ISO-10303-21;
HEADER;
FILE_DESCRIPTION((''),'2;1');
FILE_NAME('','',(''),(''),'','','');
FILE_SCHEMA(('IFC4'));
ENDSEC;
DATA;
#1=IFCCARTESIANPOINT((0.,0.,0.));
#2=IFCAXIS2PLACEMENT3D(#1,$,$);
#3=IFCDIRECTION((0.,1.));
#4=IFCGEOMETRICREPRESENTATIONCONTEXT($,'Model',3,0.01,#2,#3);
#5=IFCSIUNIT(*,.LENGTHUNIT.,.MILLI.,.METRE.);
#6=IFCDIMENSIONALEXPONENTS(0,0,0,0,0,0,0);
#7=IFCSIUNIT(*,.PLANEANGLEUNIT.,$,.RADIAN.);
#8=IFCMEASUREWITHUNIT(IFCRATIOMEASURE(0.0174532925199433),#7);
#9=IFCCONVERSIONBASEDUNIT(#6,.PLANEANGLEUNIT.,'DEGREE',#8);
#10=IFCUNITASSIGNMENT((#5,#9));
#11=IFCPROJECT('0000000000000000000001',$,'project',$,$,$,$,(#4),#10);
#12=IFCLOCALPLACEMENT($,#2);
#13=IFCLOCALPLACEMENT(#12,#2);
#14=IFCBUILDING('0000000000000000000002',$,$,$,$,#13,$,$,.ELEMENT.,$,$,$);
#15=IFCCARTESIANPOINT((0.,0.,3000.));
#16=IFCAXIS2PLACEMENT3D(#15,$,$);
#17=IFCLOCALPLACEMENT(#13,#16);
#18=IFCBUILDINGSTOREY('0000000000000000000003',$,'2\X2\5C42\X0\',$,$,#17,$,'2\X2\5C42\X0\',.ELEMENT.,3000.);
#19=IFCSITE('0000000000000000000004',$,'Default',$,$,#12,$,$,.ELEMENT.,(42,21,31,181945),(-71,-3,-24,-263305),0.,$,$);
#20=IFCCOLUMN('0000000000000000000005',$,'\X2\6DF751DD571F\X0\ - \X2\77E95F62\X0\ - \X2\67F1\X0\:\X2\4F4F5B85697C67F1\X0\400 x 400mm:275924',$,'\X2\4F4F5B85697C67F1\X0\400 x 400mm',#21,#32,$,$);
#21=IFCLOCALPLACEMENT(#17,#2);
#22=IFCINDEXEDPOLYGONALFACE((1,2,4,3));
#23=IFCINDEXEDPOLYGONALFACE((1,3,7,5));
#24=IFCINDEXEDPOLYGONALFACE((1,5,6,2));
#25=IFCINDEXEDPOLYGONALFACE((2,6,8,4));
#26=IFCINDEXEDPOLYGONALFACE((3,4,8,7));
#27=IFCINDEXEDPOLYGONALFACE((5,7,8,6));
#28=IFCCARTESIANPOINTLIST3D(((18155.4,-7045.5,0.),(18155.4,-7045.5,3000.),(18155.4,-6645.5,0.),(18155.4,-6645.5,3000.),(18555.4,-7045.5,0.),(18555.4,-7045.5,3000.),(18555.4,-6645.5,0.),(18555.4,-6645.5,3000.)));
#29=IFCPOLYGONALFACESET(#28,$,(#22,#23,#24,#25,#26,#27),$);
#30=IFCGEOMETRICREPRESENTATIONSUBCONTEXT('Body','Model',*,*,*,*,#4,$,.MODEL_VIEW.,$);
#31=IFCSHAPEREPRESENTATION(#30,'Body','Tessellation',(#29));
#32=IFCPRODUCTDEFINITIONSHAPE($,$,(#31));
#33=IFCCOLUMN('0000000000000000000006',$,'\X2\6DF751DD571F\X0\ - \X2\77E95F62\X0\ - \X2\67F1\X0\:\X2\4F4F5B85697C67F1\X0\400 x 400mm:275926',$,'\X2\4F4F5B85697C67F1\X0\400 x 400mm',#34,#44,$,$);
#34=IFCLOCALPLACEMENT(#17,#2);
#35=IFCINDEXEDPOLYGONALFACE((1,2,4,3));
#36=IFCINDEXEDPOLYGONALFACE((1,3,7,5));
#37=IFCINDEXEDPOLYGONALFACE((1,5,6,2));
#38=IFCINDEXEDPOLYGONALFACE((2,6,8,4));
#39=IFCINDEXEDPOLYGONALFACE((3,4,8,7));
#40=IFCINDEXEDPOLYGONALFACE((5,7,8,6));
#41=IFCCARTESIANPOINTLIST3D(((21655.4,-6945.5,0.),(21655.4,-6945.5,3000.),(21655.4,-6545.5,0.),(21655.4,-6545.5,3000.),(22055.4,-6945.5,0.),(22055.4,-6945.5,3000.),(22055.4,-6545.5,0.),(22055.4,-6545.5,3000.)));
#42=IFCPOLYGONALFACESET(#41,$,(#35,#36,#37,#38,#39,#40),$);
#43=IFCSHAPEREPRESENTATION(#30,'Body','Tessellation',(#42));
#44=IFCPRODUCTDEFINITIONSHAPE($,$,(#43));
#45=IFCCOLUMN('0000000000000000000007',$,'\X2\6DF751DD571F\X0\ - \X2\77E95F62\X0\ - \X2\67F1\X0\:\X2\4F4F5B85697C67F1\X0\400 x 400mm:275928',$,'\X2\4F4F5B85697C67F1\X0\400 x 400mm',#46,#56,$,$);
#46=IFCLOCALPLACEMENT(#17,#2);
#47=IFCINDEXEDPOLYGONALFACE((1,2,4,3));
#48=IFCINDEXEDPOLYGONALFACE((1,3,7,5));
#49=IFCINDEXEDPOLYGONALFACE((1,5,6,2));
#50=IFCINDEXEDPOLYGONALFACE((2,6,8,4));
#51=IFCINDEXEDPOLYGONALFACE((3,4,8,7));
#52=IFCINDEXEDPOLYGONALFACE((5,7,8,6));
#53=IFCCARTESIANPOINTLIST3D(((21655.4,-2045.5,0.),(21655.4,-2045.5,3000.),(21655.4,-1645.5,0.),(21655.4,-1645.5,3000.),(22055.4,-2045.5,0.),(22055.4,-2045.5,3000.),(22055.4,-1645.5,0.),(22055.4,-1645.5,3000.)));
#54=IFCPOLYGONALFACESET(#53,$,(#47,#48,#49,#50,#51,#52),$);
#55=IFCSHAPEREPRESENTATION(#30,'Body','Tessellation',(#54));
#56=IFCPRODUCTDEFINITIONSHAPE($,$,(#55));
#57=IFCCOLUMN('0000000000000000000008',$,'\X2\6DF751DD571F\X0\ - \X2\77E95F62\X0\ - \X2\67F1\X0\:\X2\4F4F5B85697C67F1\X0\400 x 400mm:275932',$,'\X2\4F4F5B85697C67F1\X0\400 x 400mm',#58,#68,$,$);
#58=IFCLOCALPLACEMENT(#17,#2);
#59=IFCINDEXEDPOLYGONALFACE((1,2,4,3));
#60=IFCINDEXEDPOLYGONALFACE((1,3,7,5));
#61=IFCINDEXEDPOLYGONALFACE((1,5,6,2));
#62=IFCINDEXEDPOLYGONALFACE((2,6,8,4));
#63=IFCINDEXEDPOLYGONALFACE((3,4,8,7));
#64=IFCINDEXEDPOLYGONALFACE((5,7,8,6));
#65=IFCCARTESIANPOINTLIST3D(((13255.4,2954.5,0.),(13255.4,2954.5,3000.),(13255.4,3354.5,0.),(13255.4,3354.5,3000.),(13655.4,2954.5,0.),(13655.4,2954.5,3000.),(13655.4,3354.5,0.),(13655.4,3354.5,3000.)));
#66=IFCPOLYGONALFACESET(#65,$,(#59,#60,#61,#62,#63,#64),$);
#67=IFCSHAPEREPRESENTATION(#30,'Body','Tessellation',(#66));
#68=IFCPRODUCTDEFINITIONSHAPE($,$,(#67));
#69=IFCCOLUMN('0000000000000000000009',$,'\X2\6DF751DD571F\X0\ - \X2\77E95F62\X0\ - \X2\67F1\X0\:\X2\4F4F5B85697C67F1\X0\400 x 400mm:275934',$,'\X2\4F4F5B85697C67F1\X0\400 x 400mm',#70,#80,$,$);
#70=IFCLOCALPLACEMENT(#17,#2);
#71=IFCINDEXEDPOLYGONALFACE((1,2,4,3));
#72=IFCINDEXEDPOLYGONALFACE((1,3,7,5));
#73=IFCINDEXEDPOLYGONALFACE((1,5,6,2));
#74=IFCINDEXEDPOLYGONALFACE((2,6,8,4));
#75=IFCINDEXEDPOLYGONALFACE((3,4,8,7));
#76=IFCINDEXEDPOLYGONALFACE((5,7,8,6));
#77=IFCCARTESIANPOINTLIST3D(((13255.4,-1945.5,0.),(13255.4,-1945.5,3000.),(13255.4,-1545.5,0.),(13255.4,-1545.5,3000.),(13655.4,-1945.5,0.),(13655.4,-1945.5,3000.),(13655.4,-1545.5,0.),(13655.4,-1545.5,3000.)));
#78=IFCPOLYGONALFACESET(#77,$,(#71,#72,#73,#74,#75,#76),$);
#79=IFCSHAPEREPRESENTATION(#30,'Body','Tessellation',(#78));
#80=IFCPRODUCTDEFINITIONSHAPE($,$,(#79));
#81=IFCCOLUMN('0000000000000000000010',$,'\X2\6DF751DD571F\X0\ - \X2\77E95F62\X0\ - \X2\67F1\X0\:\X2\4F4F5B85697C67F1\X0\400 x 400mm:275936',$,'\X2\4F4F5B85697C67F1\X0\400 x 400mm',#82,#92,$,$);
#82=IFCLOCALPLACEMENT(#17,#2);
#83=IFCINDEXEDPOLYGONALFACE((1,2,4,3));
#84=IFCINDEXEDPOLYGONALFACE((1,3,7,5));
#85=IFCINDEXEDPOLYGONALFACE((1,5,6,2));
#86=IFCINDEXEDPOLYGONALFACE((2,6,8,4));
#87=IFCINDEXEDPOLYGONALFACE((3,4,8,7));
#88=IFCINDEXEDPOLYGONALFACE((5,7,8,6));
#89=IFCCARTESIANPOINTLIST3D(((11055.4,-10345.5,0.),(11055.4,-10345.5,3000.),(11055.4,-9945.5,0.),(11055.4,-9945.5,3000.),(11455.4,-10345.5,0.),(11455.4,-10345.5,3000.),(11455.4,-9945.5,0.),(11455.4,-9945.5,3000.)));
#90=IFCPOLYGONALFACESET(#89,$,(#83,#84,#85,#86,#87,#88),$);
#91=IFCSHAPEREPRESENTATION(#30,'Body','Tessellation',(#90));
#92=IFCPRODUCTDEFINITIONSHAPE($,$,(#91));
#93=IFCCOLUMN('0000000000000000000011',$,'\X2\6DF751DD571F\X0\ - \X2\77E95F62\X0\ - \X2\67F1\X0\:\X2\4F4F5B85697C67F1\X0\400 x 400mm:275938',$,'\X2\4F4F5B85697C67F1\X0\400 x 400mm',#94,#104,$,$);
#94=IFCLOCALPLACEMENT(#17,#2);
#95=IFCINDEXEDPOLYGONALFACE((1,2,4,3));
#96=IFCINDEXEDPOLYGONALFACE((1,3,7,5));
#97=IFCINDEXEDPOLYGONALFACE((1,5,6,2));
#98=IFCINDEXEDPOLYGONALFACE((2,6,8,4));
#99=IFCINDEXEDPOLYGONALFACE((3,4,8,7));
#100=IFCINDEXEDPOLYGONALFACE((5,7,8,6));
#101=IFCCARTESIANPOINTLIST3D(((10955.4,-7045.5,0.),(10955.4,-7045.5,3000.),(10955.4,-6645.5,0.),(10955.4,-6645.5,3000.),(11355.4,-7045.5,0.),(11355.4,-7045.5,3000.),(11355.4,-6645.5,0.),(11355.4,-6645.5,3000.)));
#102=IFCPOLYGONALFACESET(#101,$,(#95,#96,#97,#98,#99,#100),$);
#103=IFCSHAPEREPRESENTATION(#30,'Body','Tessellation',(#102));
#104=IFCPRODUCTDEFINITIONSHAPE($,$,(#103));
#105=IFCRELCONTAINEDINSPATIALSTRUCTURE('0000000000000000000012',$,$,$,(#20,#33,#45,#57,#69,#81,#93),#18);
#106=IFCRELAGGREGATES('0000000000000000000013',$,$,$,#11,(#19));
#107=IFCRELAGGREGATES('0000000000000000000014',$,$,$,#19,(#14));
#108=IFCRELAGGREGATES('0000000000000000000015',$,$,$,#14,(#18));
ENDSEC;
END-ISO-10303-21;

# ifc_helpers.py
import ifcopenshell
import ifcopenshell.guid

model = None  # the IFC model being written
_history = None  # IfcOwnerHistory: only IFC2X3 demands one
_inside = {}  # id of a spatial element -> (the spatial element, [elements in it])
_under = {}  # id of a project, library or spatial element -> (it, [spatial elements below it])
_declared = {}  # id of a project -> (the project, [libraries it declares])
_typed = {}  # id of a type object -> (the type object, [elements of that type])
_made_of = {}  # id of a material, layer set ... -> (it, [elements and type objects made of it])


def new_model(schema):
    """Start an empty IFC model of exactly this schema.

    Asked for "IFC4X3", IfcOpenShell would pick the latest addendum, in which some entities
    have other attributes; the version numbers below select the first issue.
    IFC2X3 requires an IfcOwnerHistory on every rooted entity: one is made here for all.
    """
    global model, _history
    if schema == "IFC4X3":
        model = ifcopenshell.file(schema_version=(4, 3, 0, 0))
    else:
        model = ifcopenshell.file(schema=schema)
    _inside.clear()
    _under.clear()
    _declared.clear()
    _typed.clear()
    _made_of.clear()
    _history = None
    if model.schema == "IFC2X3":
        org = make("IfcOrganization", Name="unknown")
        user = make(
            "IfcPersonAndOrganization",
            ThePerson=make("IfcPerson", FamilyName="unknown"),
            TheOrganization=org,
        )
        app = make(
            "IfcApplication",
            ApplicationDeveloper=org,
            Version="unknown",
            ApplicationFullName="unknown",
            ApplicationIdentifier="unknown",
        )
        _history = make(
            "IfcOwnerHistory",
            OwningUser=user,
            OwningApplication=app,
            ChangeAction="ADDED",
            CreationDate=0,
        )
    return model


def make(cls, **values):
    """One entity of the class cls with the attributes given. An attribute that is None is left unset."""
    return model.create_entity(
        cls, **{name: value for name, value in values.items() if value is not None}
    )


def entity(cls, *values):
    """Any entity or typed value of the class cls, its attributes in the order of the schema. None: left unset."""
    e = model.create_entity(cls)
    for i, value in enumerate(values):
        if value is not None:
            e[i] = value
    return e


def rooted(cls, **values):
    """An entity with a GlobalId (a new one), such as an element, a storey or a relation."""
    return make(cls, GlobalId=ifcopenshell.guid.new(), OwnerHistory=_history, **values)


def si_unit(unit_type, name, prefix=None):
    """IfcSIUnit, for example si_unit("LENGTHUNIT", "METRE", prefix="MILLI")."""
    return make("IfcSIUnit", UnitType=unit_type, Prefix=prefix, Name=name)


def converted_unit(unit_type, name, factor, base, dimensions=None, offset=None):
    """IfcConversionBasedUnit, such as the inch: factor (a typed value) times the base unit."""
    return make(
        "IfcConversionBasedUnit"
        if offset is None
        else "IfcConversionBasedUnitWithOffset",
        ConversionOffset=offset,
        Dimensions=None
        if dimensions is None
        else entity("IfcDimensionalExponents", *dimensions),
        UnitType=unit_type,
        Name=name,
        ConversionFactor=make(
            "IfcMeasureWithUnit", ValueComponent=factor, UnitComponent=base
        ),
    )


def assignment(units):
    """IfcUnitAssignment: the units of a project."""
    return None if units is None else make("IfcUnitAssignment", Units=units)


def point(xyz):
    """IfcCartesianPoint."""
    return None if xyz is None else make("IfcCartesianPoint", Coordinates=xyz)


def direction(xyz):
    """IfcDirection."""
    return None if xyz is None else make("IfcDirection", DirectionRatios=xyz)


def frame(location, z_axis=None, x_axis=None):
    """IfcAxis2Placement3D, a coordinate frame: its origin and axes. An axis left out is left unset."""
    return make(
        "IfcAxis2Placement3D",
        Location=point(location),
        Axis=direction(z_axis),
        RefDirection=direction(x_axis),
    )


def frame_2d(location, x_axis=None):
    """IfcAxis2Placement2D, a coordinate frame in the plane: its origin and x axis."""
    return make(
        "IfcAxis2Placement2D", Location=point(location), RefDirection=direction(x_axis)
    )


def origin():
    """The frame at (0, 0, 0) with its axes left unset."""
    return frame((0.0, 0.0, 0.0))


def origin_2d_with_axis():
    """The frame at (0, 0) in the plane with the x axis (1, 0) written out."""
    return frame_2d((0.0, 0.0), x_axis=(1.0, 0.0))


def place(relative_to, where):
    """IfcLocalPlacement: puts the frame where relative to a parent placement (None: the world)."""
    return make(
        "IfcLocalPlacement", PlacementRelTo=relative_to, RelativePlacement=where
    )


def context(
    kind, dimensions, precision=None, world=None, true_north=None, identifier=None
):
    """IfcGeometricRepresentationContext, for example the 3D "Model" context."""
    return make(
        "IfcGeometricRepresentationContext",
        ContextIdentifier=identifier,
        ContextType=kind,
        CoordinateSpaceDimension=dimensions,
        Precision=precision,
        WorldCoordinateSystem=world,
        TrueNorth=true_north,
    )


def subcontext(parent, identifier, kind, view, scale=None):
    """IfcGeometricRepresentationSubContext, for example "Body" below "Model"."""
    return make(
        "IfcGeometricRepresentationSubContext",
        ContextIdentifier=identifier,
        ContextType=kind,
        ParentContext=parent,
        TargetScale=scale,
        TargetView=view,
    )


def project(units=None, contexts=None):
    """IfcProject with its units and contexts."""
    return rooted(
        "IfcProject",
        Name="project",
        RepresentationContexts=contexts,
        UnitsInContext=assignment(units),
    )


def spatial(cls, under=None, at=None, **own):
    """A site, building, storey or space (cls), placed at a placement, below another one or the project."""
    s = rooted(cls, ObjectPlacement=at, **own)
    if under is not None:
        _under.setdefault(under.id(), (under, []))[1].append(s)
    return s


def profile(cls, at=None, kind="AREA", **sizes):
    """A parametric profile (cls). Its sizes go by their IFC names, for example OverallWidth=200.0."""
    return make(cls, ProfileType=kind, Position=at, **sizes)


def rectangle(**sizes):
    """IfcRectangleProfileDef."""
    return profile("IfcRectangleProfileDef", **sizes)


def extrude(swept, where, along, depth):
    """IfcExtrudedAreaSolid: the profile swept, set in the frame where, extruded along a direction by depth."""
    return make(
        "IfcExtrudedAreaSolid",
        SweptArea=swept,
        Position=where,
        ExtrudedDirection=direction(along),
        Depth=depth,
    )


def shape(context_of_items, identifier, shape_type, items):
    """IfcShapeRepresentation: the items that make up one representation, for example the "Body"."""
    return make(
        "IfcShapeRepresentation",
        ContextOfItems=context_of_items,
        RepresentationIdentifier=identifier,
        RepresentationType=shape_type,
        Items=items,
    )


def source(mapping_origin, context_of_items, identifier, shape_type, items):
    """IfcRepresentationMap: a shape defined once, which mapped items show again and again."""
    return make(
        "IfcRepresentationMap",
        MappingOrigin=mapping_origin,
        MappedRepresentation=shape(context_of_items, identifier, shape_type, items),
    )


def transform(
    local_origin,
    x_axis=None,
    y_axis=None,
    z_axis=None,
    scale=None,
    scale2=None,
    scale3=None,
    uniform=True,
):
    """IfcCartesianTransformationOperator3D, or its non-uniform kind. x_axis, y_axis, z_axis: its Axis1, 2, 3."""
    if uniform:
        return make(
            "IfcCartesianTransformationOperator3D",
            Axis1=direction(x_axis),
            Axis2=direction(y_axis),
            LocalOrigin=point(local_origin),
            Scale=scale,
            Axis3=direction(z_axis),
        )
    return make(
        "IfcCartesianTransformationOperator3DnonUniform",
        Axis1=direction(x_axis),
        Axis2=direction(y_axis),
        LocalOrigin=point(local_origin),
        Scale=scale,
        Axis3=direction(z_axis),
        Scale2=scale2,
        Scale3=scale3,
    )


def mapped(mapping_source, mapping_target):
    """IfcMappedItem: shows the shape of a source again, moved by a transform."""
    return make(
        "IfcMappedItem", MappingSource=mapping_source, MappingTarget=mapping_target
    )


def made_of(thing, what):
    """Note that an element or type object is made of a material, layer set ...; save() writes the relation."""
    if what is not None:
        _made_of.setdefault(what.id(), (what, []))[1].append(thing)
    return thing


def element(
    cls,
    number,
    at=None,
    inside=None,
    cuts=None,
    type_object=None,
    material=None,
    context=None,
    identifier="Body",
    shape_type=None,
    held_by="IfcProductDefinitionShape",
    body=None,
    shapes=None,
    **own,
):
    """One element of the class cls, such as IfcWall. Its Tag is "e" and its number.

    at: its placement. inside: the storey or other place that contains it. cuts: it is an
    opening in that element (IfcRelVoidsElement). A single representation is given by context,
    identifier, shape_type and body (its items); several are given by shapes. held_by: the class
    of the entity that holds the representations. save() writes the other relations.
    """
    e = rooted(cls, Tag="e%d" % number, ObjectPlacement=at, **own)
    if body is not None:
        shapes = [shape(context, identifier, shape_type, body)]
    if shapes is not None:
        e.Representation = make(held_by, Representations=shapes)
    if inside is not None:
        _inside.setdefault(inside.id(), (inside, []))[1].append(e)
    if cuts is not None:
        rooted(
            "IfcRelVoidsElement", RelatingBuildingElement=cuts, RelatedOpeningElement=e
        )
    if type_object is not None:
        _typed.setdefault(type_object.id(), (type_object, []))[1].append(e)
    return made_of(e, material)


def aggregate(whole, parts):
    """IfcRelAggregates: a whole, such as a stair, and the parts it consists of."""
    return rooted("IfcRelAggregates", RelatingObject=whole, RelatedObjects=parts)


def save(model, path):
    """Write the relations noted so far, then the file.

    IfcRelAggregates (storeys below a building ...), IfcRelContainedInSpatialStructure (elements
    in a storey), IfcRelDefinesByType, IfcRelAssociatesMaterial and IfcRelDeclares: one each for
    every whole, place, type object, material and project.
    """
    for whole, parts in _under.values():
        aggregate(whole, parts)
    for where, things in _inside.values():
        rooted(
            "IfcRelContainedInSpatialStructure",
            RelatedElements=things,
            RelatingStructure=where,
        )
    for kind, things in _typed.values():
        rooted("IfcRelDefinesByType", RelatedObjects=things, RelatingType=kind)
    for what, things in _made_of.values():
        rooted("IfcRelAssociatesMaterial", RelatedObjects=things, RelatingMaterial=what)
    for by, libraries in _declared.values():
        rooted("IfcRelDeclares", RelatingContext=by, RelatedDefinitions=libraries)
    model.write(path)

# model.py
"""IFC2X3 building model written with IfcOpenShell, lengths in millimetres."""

from ifc_helpers import new_model, entity, si_unit, converted_unit, direction, frame, frame_2d, origin, origin_2d_with_axis, place, context, subcontext, project, spatial, rectangle, extrude, source, transform, mapped, element, save


model = new_model("IFC2X3")

# Units and contexts
model_context = context("Model", 3, precision=0.01, world=origin(), true_north=direction((0.0, 1.0)))
body_context = subcontext(model_context, "Body", "Model", "MODEL_VIEW")
ifc_project = project(units=[si_unit("LENGTHUNIT", "METRE", prefix="MILLI"), converted_unit("PLANEANGLEUNIT", "DEGREE", entity("IfcRatioMeasure", 0.0174532925199433), si_unit("PLANEANGLEUNIT", "RADIAN"), dimensions=[0, 0, 0, 0, 0, 0, 0])], contexts=[model_context])

# Site, building, storey
site_placement = place(None, origin())
site = spatial("IfcSite", under=ifc_project, at=site_placement, Name="Default", CompositionType="ELEMENT", RefLatitude=(42, 21, 31, 181945), RefLongitude=(-71, -3, -24, -263305), RefElevation=0.0)
building_placement = place(site_placement, origin())
building = spatial("IfcBuilding", under=site, at=building_placement, CompositionType="ELEMENT")
storey_placement = place(building_placement, frame((0.0, 0.0, 3000.0)))
storey = spatial("IfcBuildingStorey", under=building, at=storey_placement, Name="2层", LongName="2层", CompositionType="ELEMENT", Elevation=3000.0)

# Columns
shared_shape_1 = source(origin(), body_context, "Body", "SweptSolid", [
    extrude(rectangle(XDim=400.0, YDim=400.0, at=origin_2d_with_axis()), frame((18355.4, -6845.5, 3000.0), z_axis=(0.0, 0.0, 1.0), x_axis=(0.0, -1.0, 0.0)), (0.0, 0.0, 1.0), 3000.0),
])
column_1_placement = place(storey_placement, frame((0.0, 0.0, -3000.0)))
element("IfcColumn", 1, at=column_1_placement, inside=storey, Name="混凝土 - 矩形 - 柱:住宅楼柱400 x 400mm:275924", ObjectType="住宅楼柱400 x 400mm", context=body_context, shape_type="MappedRepresentation", body=[
    mapped(shared_shape_1, transform((0.0, 0.0, 0.0), scale=1.0)),
])
shared_shape_2 = source(origin(), body_context, "Body", "SweptSolid", [
    extrude(rectangle(XDim=400.0, YDim=400.0, at=frame_2d((0.0, 0.0), x_axis=(1.0, 0.0))), frame((21855.4, -6745.5, 3000.0), z_axis=(0.0, 0.0, 1.0), x_axis=(0.0, -1.0, 0.0)), (0.0, 0.0, 1.0), 3000.0),
])
column_2_placement = place(storey_placement, frame((0.0, 0.0, -3000.0)))
element("IfcColumn", 2, at=column_2_placement, inside=storey, Name="混凝土 - 矩形 - 柱:住宅楼柱400 x 400mm:275926", ObjectType="住宅楼柱400 x 400mm", context=body_context, shape_type="MappedRepresentation", body=[
    mapped(shared_shape_2, transform((0.0, 0.0, 0.0), scale=1.0)),
])
shared_shape_3 = source(origin(), body_context, "Body", "SweptSolid", [
    extrude(rectangle(XDim=400.0, YDim=400.0, at=frame_2d((0.0, 0.0), x_axis=(1.0, 0.0))), frame((21855.4, -1845.5, 3000.0), z_axis=(0.0, 0.0, 1.0), x_axis=(0.0, -1.0, 0.0)), (0.0, 0.0, 1.0), 3000.0),
])
column_3_placement = place(storey_placement, frame((0.0, 0.0, -3000.0)))
element("IfcColumn", 3, at=column_3_placement, inside=storey, Name="混凝土 - 矩形 - 柱:住宅楼柱400 x 400mm:275928", ObjectType="住宅楼柱400 x 400mm", context=body_context, shape_type="MappedRepresentation", body=[
    mapped(shared_shape_3, transform((0.0, 0.0, 0.0), scale=1.0)),
])
shared_shape_4 = source(origin(), body_context, "Body", "SweptSolid", [
    extrude(rectangle(XDim=400.0, YDim=400.0, at=origin_2d_with_axis()), frame((13455.4, 3154.5, 3000.0), z_axis=(0.0, 0.0, 1.0), x_axis=(0.0, -1.0, 0.0)), (0.0, 0.0, 1.0), 3000.0),
])
column_4_placement = place(storey_placement, frame((0.0, 0.0, -3000.0)))
element("IfcColumn", 4, at=column_4_placement, inside=storey, Name="混凝土 - 矩形 - 柱:住宅楼柱400 x 400mm:275932", ObjectType="住宅楼柱400 x 400mm", context=body_context, shape_type="MappedRepresentation", body=[
    mapped(shared_shape_4, transform((0.0, 0.0, 0.0), scale=1.0)),
])
shared_shape_5 = source(origin(), body_context, "Body", "SweptSolid", [
    extrude(rectangle(XDim=400.0, YDim=400.0, at=origin_2d_with_axis()), frame((13455.4, -1745.5, 3000.0), z_axis=(0.0, 0.0, 1.0), x_axis=(0.0, -1.0, 0.0)), (0.0, 0.0, 1.0), 3000.0),
])
column_5_placement = place(storey_placement, frame((0.0, 0.0, -3000.0)))
element("IfcColumn", 5, at=column_5_placement, inside=storey, Name="混凝土 - 矩形 - 柱:住宅楼柱400 x 400mm:275934", ObjectType="住宅楼柱400 x 400mm", context=body_context, shape_type="MappedRepresentation", body=[
    mapped(shared_shape_5, transform((0.0, 0.0, 0.0), scale=1.0)),
])
shared_shape_6 = source(origin(), body_context, "Body", "SweptSolid", [
    extrude(rectangle(XDim=400.0, YDim=400.0, at=origin_2d_with_axis()), frame((11255.4, -10145.5, 3000.0), z_axis=(0.0, 0.0, 1.0), x_axis=(0.0, -1.0, 0.0)), (0.0, 0.0, 1.0), 3000.0),
])
column_6_placement = place(storey_placement, frame((0.0, 0.0, -3000.0)))
element("IfcColumn", 6, at=column_6_placement, inside=storey, Name="混凝土 - 矩形 - 柱:住宅楼柱400 x 400mm:275936", ObjectType="住宅楼柱400 x 400mm", context=body_context, shape_type="MappedRepresentation", body=[
    mapped(shared_shape_6, transform((0.0, 0.0, 0.0), scale=1.0)),
])
shared_shape_7 = source(origin(), body_context, "Body", "SweptSolid", [
    extrude(rectangle(XDim=400.0, YDim=400.0, at=origin_2d_with_axis()), frame((11155.4, -6845.5, 3000.0), z_axis=(0.0, 0.0, 1.0), x_axis=(0.0, -1.0, 0.0)), (0.0, 0.0, 1.0), 3000.0),
])
column_7_placement = place(storey_placement, frame((0.0, 0.0, -3000.0)))
element("IfcColumn", 7, at=column_7_placement, inside=storey, Name="混凝土 - 矩形 - 柱:住宅楼柱400 x 400mm:275938", ObjectType="住宅楼柱400 x 400mm", context=body_context, shape_type="MappedRepresentation", body=[
    mapped(shared_shape_7, transform((0.0, 0.0, 0.0), scale=1.0)),
])

save(model, "model.ifc")
